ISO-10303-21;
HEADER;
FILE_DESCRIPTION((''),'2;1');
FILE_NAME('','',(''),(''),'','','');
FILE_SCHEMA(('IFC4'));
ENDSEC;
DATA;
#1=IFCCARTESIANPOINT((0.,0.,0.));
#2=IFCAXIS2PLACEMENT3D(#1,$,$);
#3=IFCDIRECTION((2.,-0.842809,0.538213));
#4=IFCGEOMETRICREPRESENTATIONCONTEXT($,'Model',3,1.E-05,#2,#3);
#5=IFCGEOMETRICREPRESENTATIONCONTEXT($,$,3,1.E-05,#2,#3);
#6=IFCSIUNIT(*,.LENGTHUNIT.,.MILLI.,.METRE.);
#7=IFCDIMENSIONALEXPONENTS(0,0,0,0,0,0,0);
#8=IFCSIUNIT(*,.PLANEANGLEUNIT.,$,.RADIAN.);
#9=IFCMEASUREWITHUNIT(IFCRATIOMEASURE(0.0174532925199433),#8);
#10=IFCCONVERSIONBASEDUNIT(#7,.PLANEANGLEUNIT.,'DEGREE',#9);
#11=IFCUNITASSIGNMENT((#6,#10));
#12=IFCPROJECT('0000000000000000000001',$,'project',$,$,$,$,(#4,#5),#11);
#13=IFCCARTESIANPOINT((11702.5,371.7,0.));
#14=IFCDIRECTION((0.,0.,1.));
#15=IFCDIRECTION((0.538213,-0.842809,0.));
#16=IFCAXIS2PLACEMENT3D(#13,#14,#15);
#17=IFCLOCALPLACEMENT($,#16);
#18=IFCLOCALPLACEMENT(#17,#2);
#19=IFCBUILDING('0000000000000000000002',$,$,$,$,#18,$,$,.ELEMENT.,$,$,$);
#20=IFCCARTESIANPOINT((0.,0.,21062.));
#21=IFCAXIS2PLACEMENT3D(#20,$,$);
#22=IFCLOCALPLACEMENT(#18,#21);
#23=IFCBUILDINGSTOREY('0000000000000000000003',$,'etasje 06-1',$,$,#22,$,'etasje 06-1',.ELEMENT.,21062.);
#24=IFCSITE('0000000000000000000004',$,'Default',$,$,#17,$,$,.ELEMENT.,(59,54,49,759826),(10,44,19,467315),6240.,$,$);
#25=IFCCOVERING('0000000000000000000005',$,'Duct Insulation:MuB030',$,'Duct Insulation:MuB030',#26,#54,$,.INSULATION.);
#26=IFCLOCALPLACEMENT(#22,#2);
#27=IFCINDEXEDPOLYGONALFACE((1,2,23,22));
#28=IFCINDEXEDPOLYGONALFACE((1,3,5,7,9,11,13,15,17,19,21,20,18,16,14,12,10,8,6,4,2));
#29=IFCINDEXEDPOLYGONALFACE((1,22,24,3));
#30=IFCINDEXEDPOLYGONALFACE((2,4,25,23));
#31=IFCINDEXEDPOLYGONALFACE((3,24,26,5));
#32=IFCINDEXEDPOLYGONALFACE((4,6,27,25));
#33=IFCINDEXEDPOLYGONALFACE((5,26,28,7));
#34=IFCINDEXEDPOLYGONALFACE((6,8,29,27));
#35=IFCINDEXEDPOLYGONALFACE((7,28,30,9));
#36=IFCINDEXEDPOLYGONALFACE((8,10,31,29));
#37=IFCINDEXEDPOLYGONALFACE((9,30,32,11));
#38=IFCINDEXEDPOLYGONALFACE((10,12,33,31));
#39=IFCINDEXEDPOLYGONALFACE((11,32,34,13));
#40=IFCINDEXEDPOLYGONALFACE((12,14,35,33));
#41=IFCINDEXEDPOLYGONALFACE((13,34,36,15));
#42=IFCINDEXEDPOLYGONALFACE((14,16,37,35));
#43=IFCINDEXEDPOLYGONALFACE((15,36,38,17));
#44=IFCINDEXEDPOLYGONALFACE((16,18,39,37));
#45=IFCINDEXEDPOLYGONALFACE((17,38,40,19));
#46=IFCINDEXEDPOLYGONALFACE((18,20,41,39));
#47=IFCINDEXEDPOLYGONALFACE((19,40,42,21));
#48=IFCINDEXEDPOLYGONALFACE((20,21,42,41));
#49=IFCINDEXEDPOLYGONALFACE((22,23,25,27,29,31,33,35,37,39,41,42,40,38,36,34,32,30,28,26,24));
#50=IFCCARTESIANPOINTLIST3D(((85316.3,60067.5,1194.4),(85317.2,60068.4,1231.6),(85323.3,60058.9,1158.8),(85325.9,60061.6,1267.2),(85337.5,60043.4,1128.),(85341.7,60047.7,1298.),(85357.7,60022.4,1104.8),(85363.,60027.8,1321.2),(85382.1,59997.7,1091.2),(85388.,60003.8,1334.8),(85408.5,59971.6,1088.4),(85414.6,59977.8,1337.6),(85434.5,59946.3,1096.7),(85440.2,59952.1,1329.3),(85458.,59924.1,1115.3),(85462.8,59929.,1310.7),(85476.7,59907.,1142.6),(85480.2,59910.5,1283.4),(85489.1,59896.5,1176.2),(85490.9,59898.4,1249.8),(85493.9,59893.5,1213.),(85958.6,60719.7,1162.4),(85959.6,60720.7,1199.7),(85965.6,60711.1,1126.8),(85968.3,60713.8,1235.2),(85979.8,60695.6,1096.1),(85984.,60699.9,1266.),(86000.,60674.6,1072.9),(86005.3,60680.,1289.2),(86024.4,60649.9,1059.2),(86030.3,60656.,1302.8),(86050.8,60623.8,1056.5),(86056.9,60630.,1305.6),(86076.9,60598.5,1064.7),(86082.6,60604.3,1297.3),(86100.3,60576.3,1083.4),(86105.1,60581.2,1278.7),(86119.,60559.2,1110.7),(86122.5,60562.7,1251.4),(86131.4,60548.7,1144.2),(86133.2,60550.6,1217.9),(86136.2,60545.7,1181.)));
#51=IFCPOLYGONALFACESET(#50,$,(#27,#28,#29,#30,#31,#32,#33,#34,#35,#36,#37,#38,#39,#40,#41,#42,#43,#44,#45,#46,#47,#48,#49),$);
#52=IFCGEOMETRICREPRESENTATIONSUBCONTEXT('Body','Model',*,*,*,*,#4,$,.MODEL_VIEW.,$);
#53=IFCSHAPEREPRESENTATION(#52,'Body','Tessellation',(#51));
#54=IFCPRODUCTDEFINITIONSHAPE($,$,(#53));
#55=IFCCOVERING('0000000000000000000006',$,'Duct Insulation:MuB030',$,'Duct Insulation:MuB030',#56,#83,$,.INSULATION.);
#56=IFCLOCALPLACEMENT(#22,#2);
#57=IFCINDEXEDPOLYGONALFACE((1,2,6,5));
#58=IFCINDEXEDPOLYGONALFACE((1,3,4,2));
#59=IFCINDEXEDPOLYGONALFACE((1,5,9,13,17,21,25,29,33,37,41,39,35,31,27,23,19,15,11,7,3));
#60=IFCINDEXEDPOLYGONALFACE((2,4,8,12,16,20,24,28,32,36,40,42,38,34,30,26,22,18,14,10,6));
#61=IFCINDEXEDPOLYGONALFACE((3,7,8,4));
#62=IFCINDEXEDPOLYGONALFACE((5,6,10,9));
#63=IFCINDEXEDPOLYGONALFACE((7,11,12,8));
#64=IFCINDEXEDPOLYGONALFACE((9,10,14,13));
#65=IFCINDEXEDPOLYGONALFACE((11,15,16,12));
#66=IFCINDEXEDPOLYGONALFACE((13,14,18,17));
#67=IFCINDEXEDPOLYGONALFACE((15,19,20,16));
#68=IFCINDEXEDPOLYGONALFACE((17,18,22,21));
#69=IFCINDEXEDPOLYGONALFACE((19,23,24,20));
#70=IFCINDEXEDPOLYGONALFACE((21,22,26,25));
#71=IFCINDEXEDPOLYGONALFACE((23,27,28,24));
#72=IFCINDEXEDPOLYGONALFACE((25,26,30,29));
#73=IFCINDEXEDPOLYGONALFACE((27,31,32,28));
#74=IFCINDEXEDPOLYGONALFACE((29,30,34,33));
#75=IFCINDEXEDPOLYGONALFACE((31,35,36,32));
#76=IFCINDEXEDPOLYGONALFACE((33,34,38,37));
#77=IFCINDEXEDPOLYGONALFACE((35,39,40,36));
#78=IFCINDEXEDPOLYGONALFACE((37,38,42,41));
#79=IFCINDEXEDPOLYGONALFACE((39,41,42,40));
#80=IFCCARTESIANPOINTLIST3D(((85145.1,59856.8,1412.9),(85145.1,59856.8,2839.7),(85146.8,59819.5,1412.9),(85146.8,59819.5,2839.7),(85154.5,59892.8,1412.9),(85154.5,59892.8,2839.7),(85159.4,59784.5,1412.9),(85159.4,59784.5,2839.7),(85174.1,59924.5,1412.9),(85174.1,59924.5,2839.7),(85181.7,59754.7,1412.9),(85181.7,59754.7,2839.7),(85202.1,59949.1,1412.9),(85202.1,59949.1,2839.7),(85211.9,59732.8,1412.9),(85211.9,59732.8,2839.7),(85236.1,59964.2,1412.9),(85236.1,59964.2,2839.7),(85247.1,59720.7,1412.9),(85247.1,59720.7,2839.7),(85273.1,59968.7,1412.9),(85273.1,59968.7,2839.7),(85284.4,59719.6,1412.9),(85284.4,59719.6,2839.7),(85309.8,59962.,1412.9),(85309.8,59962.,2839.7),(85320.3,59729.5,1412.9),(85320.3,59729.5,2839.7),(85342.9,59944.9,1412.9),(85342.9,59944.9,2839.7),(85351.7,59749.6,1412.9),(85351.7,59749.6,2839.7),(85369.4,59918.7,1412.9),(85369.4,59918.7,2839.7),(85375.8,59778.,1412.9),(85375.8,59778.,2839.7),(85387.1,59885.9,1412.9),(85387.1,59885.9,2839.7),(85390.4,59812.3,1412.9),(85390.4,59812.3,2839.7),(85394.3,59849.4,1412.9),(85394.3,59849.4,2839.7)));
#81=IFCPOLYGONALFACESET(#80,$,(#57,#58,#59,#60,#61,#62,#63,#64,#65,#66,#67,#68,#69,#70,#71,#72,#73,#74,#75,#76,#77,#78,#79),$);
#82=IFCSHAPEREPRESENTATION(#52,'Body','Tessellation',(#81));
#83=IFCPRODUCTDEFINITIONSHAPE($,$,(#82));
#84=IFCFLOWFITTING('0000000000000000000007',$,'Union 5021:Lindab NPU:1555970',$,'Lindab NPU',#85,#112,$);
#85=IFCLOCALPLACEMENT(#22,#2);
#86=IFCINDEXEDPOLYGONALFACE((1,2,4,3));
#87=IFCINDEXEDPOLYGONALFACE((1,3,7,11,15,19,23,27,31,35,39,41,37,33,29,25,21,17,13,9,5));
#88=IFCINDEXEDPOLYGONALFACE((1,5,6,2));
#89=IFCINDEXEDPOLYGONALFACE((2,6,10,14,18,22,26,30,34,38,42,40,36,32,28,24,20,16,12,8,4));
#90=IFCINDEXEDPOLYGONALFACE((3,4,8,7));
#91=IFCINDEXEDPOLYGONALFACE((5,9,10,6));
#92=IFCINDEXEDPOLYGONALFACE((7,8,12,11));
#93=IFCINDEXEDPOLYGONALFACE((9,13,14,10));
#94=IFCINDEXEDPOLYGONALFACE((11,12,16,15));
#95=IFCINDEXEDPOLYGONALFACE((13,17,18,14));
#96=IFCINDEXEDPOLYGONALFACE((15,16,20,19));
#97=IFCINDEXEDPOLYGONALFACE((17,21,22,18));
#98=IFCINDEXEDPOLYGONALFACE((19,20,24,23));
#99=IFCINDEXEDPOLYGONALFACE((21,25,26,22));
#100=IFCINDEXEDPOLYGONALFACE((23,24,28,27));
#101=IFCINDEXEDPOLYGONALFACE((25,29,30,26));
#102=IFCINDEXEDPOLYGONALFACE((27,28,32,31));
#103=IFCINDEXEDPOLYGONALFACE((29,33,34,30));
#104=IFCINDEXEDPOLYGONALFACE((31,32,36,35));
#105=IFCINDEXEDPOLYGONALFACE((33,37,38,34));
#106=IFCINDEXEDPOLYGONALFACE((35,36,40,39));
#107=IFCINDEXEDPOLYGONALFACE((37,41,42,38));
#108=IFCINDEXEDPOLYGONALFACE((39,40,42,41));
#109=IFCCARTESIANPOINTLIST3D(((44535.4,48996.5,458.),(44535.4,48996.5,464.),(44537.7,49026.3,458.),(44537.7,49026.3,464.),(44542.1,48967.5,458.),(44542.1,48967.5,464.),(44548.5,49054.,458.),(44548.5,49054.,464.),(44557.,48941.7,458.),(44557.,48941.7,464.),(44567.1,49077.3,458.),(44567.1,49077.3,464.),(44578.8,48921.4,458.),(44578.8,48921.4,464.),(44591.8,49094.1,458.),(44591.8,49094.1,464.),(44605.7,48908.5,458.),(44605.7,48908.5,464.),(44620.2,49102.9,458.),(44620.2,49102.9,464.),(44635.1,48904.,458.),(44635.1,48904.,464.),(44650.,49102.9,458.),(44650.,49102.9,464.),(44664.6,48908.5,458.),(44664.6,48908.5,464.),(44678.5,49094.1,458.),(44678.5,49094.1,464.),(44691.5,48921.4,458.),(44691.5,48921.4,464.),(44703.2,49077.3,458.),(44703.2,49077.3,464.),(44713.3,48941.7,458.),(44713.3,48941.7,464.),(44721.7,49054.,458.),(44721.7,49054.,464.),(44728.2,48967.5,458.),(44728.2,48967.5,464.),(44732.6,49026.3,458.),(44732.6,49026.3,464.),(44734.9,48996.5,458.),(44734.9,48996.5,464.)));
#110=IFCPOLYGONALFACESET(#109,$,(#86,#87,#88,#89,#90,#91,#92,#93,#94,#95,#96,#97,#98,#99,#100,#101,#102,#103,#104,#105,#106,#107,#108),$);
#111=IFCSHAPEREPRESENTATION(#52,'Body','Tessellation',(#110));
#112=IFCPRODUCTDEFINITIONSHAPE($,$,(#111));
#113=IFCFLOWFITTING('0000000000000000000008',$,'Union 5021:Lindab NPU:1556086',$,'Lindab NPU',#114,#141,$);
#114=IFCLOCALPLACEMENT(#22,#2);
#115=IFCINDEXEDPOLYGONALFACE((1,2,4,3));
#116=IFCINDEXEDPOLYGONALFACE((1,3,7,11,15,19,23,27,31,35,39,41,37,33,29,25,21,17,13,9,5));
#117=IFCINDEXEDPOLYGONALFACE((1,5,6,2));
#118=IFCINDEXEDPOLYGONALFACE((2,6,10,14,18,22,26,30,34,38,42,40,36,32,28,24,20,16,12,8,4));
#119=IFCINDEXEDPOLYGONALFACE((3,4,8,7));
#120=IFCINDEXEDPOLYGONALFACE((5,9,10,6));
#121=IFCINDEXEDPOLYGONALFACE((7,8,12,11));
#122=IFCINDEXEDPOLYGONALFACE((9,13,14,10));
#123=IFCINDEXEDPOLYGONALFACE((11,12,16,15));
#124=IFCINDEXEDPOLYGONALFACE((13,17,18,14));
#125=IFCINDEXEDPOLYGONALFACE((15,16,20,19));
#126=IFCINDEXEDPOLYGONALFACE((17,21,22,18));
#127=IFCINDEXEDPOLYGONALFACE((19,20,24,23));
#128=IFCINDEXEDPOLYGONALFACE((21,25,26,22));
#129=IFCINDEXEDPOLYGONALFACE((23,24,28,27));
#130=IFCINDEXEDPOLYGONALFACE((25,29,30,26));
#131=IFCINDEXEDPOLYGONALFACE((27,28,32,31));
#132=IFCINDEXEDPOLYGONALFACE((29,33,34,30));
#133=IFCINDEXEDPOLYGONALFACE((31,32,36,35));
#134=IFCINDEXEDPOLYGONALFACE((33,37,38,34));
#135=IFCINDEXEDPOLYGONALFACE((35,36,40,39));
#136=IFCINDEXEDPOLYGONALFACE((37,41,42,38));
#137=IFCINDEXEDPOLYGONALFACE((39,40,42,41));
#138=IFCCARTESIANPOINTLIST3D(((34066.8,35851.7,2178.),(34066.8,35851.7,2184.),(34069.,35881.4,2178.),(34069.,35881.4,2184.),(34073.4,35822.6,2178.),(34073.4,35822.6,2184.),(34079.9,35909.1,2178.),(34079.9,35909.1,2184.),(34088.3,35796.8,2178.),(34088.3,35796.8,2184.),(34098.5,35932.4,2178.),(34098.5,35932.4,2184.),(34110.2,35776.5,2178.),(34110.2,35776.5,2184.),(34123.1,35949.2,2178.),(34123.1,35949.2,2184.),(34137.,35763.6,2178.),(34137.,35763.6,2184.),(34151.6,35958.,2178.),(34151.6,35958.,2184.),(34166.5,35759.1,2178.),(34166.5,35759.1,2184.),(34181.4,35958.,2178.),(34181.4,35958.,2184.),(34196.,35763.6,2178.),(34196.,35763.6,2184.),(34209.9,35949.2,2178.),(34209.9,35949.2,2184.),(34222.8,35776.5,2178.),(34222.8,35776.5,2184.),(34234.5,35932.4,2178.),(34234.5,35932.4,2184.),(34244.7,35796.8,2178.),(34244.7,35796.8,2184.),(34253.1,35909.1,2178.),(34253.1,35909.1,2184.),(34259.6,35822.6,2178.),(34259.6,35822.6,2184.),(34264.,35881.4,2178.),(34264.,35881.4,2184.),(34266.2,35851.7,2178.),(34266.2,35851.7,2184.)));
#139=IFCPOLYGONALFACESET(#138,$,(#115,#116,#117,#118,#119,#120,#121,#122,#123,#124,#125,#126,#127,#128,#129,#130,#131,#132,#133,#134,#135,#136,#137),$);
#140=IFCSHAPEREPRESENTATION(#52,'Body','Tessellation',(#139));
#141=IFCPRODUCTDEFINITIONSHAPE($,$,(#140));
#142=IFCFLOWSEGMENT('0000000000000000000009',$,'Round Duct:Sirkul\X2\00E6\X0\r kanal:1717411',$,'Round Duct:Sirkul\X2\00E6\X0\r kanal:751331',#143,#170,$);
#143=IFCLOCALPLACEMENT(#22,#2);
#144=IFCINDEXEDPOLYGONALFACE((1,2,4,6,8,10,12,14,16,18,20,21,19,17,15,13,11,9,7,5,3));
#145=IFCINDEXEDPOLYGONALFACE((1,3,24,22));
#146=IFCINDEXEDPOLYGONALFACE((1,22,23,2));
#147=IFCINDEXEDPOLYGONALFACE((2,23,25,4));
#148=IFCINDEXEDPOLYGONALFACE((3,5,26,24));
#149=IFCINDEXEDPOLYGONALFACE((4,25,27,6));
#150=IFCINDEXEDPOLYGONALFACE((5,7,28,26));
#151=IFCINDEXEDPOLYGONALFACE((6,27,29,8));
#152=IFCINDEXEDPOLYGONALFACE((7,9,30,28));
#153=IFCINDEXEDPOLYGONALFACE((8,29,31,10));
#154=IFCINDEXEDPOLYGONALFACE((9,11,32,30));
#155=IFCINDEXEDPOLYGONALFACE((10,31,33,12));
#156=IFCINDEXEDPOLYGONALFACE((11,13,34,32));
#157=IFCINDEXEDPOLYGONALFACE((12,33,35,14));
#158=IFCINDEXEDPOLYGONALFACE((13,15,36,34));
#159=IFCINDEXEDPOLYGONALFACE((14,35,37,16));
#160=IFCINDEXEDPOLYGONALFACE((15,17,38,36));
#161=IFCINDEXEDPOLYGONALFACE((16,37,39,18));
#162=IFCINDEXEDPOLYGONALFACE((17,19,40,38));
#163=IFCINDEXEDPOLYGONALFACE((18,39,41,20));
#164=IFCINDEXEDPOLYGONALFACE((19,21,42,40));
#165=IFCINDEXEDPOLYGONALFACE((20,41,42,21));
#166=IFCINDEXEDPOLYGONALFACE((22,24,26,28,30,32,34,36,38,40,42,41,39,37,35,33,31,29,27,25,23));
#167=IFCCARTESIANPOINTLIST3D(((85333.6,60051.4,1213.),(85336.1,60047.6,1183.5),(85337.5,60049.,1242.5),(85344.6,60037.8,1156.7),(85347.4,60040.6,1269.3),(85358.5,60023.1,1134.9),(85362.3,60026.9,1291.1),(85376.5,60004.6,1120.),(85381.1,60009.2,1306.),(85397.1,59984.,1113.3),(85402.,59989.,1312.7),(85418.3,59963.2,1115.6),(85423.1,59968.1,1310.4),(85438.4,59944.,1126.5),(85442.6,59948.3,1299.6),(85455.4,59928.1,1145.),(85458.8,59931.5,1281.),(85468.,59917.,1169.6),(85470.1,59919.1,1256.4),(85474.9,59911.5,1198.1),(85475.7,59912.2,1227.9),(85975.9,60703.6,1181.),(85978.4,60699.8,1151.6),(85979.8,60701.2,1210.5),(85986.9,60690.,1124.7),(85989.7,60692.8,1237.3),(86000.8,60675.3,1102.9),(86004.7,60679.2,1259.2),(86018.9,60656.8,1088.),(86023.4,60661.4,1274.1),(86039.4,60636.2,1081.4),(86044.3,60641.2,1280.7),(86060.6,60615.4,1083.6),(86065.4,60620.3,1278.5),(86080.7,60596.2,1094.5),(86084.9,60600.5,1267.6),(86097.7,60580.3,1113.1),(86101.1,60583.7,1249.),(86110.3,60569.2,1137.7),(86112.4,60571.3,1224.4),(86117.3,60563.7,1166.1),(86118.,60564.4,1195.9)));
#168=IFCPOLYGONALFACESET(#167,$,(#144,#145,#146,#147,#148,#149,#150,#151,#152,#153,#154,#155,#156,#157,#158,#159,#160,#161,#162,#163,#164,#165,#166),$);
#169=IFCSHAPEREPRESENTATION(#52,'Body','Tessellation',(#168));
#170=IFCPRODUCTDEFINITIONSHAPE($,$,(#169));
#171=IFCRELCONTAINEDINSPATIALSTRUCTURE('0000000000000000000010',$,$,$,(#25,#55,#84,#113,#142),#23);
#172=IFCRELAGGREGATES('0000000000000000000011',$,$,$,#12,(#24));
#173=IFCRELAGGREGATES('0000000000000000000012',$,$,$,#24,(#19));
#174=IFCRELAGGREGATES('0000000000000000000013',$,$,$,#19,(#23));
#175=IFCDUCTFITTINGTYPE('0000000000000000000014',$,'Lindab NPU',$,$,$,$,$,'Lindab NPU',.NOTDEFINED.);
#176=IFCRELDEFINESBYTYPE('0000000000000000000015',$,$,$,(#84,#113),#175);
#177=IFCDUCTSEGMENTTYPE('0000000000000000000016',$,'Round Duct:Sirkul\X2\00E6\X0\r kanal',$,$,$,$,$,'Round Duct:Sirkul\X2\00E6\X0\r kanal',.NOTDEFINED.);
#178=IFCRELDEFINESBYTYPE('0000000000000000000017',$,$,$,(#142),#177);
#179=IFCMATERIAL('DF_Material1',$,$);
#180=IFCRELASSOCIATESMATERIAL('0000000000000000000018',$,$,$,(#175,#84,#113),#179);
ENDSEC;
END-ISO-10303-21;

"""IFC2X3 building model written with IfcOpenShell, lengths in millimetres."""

from ifc_helpers import new_model, entity, si_unit, converted_unit, direction, frame, frame_2d, origin, origin_2d_with_axis, place, context, subcontext, project, spatial, circle, extrude, source, transform, mapped, material, type_object, type_shapes, element, save


model = new_model("IFC2X3")

# Units and contexts
model_context = context("Model", 3, precision=1e-05, world=origin(), true_north=direction((2.0, -0.842809, 0.538213)))
context_of_model = context(None, 3, precision=1e-05, world=origin(), true_north=direction((2.0, -0.842809, 0.538213)))
body_context = subcontext(model_context, "Body", "Model", "MODEL_VIEW")
ifc_project = project(units=[si_unit("LENGTHUNIT", "METRE", prefix="MILLI"), converted_unit("PLANEANGLEUNIT", "DEGREE", entity("IfcRatioMeasure", 0.0174532925199433), si_unit("PLANEANGLEUNIT", "RADIAN"), dimensions=[0, 0, 0, 0, 0, 0, 0])], contexts=[model_context, context_of_model])

# Site, building, storey
site_placement = place(None, frame((11702.5, 371.7, 0.0), z_axis=(0.0, 0.0, 1.0), x_axis=(0.538213, -0.842809, 0.0)))
site = spatial("IfcSite", under=ifc_project, at=site_placement, Name="Default", CompositionType="ELEMENT", RefLatitude=(59, 54, 49, 759826), RefLongitude=(10, 44, 19, 467315), RefElevation=6240.0)
building_placement = place(site_placement, origin())
building = spatial("IfcBuilding", under=site, at=building_placement, CompositionType="ELEMENT")
storey_placement = place(building_placement, frame((0.0, 0.0, 21062.0)))
storey = spatial("IfcBuildingStorey", under=building, at=storey_placement, Name="etasje 06-1", LongName="etasje 06-1", CompositionType="ELEMENT", Elevation=21062.0)

# Coverings
covering_1_placement = place(storey_placement, origin())
element("IfcCovering", 1, at=covering_1_placement, inside=storey, Name="Duct Insulation:MuB030", ObjectType="Duct Insulation:MuB030", PredefinedType="INSULATION", context=body_context, shape_type="SweptSolid", body=[
    extrude(circle(Radius=125.0, at=frame_2d((0.0, 0.0), x_axis=(1.0, 0.0))), frame((85404.9, 59981.2, 1213.0), z_axis=(0.701254, 0.712056, -0.034899), x_axis=(0.71249, -0.701682, 0.0)), (0.0, 0.0, 1.0), 915.9),
])
covering_2_placement = place(storey_placement, origin())
element("IfcCovering", 2, at=covering_2_placement, inside=storey, Name="Duct Insulation:MuB030", ObjectType="Duct Insulation:MuB030", PredefinedType="INSULATION", context=body_context, shape_type="SweptSolid", body=[
    extrude(circle(Radius=125.0, at=origin_2d_with_axis()), frame((85269.4, 59843.7, 1412.9), z_axis=(0.0, 0.0, 1.0), x_axis=(-0.701682, -0.71249, 0.0)), (0.0, 0.0, 1.0), 1426.9),
])

# Flow fittings
ifc_material = material(Name="DF_Material1")
duct_fitting_type = type_object("IfcDuctFittingType", Name="Lindab NPU", ElementType="Lindab NPU", PredefinedType="NOTDEFINED", material=ifc_material)
shared_shape = source(origin(), body_context, "Body", "SweptSolid", [
    extrude(circle(Radius=100.0, at=frame_2d((0.0, 0.0), x_axis=(1.0, 0.0))), frame((0.0, 0.0, 0.0), z_axis=(1.0, 0.0, 0.0), x_axis=(0.0, 1.0, 0.0)), (0.0, 0.0, 1.0), 6.0),
])
type_shapes(duct_fitting_type, [shared_shape])
for number, where, z_axis, x_axis, name in (
    (3, (44635.1, 49004.0, 458.0), (1.0, 0.0, 0.0), (0.0, 0.0, 1.0), "Union 5021:Lindab NPU:1555970"),
    (4, (34166.5, 35859.1, 2178.0), (1.0, 0.0, 0.0), (0.0, 0.0, 1.0), "Union 5021:Lindab NPU:1556086"),
):
    element("IfcFlowFitting", number, at=place(storey_placement, frame(where, z_axis=z_axis, x_axis=x_axis)), inside=storey, type_object=duct_fitting_type, material=ifc_material, Name=name, ObjectType="Lindab NPU", context=body_context, shape_type="MappedRepresentation", body=[
        mapped(shared_shape, transform((0.0, 0.0, 0.0), scale=1.0)),
    ])

# Flow segment
duct_segment_type = type_object("IfcDuctSegmentType", Name="Round Duct:Sirkulær kanal", ElementType="Round Duct:Sirkulær kanal", PredefinedType="NOTDEFINED")
flow_segment_1_placement = place(storey_placement, origin())
element("IfcFlowSegment", 5, at=flow_segment_1_placement, inside=storey, type_object=duct_segment_type, Name="Round Duct:Sirkulær kanal:1717411", ObjectType="Round Duct:Sirkulær kanal:751331", context=body_context, shape_type="SweptSolid", body=[
    extrude(circle(Radius=100.0, at=origin_2d_with_axis()), frame((86047.2, 60633.5, 1181.0), z_axis=(-0.701254, -0.712056, 0.034899), x_axis=(-0.71249, 0.701682, 0.0)), (0.0, 0.0, 1.0), 915.9),
])

save(model, "model.ifc")
